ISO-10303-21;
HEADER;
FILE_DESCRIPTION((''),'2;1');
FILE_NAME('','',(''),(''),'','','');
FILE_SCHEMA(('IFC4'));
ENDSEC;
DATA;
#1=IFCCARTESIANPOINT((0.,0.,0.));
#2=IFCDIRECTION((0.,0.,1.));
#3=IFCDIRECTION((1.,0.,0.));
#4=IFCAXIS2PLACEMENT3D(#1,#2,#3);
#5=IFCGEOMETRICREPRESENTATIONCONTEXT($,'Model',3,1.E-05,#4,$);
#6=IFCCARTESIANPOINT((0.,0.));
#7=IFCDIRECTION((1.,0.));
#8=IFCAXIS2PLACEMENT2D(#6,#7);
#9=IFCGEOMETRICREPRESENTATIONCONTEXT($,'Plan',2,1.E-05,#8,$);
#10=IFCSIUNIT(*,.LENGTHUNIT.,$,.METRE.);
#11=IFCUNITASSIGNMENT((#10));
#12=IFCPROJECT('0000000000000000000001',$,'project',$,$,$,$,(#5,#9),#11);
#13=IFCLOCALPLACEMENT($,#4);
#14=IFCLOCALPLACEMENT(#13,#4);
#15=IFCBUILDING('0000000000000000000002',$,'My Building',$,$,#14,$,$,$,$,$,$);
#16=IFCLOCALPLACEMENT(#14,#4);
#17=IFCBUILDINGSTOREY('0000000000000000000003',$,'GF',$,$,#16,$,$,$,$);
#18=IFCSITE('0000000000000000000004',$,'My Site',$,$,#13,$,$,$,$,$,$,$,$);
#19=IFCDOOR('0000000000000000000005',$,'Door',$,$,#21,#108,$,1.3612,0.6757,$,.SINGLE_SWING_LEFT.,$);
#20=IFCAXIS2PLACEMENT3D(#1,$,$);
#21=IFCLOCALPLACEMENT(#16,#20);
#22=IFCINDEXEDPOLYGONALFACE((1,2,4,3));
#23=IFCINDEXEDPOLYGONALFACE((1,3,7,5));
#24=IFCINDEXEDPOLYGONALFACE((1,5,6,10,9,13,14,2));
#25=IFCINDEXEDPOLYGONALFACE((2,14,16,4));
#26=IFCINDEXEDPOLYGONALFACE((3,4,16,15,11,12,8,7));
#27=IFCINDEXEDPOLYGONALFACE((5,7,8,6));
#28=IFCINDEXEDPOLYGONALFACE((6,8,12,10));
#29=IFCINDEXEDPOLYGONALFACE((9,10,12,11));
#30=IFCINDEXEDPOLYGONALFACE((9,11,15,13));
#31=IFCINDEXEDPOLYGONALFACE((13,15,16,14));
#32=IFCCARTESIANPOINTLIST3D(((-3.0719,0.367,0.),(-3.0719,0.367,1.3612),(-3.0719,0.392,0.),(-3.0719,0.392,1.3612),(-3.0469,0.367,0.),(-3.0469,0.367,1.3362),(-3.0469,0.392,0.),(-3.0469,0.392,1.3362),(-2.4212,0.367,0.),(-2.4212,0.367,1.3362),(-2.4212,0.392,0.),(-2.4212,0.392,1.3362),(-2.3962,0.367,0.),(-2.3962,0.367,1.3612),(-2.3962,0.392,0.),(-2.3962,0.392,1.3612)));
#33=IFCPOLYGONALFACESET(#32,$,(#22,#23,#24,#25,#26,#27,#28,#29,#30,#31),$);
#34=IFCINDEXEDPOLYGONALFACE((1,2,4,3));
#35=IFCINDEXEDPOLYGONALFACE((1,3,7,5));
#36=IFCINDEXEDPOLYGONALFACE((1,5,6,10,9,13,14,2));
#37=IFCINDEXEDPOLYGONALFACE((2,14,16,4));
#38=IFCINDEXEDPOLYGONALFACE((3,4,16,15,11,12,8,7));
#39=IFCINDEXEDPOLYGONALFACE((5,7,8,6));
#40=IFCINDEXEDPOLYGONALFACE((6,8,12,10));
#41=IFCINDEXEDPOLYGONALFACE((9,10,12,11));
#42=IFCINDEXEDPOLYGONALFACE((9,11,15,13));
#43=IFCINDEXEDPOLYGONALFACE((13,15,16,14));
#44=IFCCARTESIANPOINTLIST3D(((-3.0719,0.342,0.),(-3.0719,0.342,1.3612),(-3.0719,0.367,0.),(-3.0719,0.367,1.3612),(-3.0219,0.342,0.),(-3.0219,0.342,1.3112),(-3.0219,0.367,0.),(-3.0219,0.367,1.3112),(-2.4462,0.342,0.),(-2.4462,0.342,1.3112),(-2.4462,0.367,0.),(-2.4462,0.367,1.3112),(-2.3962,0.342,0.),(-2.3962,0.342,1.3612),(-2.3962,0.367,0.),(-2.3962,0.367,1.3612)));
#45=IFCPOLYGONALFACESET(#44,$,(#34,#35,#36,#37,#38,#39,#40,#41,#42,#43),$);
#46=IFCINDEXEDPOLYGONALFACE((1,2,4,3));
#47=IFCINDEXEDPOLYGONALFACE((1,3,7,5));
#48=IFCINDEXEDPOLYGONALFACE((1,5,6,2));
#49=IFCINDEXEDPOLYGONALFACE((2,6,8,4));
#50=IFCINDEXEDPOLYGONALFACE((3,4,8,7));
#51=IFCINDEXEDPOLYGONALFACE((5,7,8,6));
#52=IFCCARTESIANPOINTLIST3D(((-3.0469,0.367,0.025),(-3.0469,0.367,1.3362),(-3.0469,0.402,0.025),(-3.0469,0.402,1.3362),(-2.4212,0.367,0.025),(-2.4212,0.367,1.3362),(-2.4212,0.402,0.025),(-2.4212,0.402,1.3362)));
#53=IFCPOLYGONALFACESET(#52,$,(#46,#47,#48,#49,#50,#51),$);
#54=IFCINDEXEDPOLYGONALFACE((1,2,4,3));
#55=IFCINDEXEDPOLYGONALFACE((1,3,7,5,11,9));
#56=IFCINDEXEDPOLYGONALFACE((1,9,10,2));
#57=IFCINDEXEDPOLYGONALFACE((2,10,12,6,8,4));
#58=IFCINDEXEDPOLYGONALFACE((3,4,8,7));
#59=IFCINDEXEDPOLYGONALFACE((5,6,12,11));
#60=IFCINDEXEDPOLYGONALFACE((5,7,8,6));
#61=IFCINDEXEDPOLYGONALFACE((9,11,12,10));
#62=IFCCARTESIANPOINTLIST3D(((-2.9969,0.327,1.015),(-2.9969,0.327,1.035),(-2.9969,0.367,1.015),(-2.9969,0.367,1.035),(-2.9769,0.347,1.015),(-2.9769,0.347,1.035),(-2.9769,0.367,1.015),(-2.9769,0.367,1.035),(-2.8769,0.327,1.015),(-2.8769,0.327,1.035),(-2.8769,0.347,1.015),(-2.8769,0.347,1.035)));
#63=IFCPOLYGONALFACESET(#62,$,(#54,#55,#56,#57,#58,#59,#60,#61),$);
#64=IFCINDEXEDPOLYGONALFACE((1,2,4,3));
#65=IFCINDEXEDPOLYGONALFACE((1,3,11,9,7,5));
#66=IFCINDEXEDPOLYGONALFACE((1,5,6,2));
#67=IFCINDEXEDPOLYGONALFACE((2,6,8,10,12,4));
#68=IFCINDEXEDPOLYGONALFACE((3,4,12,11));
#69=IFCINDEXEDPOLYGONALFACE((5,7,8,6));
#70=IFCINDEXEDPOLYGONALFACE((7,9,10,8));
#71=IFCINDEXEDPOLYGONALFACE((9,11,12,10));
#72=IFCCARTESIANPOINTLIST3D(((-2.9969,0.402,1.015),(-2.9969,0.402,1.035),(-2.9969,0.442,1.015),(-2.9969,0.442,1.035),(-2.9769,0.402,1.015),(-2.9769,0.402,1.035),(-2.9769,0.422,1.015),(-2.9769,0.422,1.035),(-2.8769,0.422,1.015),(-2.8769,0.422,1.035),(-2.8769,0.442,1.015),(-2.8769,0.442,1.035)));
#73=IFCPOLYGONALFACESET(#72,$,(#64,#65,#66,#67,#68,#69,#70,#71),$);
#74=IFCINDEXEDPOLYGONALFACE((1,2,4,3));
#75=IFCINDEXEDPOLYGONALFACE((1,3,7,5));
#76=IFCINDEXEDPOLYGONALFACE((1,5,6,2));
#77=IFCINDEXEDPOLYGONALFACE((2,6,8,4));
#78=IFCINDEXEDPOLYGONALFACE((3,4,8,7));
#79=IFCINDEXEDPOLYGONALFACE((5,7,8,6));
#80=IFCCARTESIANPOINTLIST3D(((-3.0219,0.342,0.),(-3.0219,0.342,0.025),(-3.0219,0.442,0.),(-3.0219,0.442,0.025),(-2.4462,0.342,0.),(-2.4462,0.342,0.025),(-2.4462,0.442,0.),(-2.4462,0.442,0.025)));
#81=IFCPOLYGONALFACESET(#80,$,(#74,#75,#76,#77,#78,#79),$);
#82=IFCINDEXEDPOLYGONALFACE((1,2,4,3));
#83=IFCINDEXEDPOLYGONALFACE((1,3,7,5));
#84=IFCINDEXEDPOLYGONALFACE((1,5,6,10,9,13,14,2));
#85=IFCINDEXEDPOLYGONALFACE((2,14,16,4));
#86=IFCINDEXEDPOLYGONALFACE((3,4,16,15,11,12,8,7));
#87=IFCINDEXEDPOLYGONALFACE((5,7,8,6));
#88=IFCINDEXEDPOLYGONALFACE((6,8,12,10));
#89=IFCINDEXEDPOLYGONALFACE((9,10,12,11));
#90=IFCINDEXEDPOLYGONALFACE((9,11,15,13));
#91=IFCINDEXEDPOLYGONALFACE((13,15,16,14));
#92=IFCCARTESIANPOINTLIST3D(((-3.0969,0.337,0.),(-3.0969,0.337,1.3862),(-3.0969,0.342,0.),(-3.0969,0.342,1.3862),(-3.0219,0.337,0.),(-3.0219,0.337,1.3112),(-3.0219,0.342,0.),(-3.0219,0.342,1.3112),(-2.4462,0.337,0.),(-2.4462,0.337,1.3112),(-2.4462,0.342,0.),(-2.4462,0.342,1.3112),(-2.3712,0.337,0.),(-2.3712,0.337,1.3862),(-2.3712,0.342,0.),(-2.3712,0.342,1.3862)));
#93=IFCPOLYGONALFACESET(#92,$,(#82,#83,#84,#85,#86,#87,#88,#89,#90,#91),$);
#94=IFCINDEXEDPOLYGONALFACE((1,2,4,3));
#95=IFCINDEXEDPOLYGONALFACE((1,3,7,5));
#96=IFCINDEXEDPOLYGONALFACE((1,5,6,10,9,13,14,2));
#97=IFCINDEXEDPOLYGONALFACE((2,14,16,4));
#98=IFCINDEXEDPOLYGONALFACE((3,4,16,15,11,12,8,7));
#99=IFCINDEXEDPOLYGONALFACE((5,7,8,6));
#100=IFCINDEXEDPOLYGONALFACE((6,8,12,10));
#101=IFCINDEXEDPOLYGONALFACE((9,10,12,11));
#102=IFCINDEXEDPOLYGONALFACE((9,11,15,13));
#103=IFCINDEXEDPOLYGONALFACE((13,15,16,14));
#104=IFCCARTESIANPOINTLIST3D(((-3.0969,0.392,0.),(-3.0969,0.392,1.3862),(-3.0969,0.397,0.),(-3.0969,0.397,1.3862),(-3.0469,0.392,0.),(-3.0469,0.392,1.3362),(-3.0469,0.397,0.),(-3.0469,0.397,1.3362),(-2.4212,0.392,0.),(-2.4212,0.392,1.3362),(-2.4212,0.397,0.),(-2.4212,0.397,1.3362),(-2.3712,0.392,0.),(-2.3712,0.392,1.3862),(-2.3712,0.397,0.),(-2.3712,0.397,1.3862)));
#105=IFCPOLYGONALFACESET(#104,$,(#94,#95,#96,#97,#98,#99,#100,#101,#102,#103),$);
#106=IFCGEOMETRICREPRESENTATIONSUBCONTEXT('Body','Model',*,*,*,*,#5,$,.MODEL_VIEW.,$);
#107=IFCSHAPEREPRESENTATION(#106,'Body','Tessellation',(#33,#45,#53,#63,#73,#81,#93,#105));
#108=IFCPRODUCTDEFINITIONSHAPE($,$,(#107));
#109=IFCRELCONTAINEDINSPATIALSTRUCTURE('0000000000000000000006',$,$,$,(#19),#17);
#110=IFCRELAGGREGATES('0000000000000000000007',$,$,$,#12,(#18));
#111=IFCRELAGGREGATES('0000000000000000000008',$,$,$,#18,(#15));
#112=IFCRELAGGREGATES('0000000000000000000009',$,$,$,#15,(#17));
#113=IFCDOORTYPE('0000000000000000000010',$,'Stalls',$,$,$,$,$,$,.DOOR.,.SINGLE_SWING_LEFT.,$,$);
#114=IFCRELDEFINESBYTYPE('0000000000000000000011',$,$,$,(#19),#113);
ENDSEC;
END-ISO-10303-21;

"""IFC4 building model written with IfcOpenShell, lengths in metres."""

from ifc_helpers import new_model, entity, si_unit, frame, origin_with_axes, origin_2d_with_axis, place, context, subcontext, project, spatial, line, indexed_curve, outline, extrude, shape, source, transform, mapped, type_object, type_shapes, element, save


model = new_model("IFC4")

# Units and contexts
model_context = context("Model", 3, precision=1e-05, world=origin_with_axes())
plan_context = context("Plan", 2, precision=1e-05, world=origin_2d_with_axis())
body_context_1 = subcontext(model_context, "Body", "Model", "MODEL_VIEW")
body_context_2 = subcontext(plan_context, "Body", "Plan", "PLAN_VIEW")
ifc_project = project(units=[si_unit("LENGTHUNIT", "METRE")], contexts=[model_context, plan_context])

# Site, building, storey
site_placement = place(None, origin_with_axes())
site = spatial("IfcSite", under=ifc_project, at=site_placement, Name="My Site")
building_placement = place(site_placement, origin_with_axes())
building = spatial("IfcBuilding", under=site, at=building_placement, Name="My Building")
storey_placement = place(building_placement, origin_with_axes())
storey = spatial("IfcBuildingStorey", under=building, at=storey_placement, Name="GF")

# Shared definitions
door_type = type_object("IfcDoorType", Name="Stalls", OperationType="SINGLE_SWING_LEFT", PredefinedType="DOOR")
shared_shape_1 = source(origin_with_axes(), body_context_1, "Body", "SweptSolid", [
    extrude(outline(indexed_curve([(0.0, 0.0), (0.0, 1.3612), (0.6757, 1.3612), (0.6757, 0.0), (0.6507, 0.0), (0.6507, 1.3362), (0.025, 1.3362), (0.025, 0.0)], segments=[line(1, 2, 3, 4, 5, 6, 7, 8, 1)])), frame((0.0, 0.025, 0.0), z_axis=(0.0, -1.0, 0.0), x_axis=(1.0, 0.0, 0.0)), (0.0, 0.0, -1.0), 0.025),
    extrude(outline(indexed_curve([(0.0, 0.0), (0.0, 1.3612), (0.6757, 1.3612), (0.6757, 0.0), (0.6257, 0.0), (0.6257, 1.3112), (0.05, 1.3112), (0.05, 0.0)], segments=[line(1, 2, 3, 4, 5, 6, 7, 8, 1)])), frame((0.0, 0.0, 0.0), z_axis=(0.0, -1.0, 0.0), x_axis=(1.0, 0.0, 0.0)), (0.0, 0.0, -1.0), 0.025),
    extrude(outline(indexed_curve([(0.0, 0.0), (0.6257, 0.0), (0.6257, 0.035), (0.0, 0.035)], segments=[line(1, 2, 3, 4, 1)])), frame((0.025, 0.025, 0.025), z_axis=(0.0, 0.0, 1.0), x_axis=(1.0, 0.0, 0.0)), (0.0, 0.0, 1.0), 1.3112),
    extrude(outline(indexed_curve([(0.0, 0.0), (0.0, -0.04), (0.12, -0.04), (0.12, -0.02), (0.02, -0.02), (0.02, 0.0)], segments=[line(1, 2, 3, 4, 5, 6, 1)])), frame((0.075, 0.025, 1.015), z_axis=(0.0, 0.0, 1.0), x_axis=(1.0, 0.0, 0.0)), (0.0, 0.0, 1.0), 0.02),
    extrude(outline(indexed_curve([(0.0, 0.0), (0.0, 0.04), (0.12, 0.04), (0.12, 0.02), (0.02, 0.02), (0.02, 0.0)], segments=[line(1, 2, 3, 4, 5, 6, 1)])), frame((0.075, 0.06, 1.015), z_axis=(0.0, 0.0, 1.0), x_axis=(1.0, 0.0, 0.0)), (0.0, 0.0, 1.0), 0.02),
    extrude(outline(indexed_curve([(0.0, 0.0), (0.5757, 0.0), (0.5757, 0.1), (0.0, 0.1)], segments=[line(1, 2, 3, 4, 1)])), frame((0.05, 0.0, 0.0), z_axis=(0.0, 0.0, 1.0), x_axis=(1.0, 0.0, 0.0)), (0.0, 0.0, 1.0), 0.025),
    extrude(outline(indexed_curve([(0.0, 0.0), (0.0, 1.3862), (0.7257, 1.3862), (0.7257, 0.0), (0.6507, 0.0), (0.6507, 1.3112), (0.075, 1.3112), (0.075, 0.0)], segments=[line(1, 2, 3, 4, 5, 6, 7, 8, 1)])), frame((-0.025, -0.005, 0.0), z_axis=(0.0, -1.0, 0.0), x_axis=(1.0, 0.0, 0.0)), (0.0, 0.0, -1.0), 0.005),
    extrude(outline(indexed_curve([(0.0, 0.0), (0.0, 1.3862), (0.7257, 1.3862), (0.7257, 0.0), (0.6757, 0.0), (0.6757, 1.3362), (0.05, 1.3362), (0.05, 0.0)], segments=[line(1, 2, 3, 4, 5, 6, 7, 8, 1)])), frame((-0.025, 0.05, 0.0), z_axis=(0.0, -1.0, 0.0), x_axis=(1.0, 0.0, 0.0)), (0.0, 0.0, -1.0), 0.005),
])
shared_shape_2 = source(origin_with_axes(), body_context_2, "Body", "Curve2D", [
    entity("IfcIndexedPolyCurve", entity("IfcCartesianPointList2D", [[0.0, 0.0], [0.0, 0.05], [0.025, 0.05], [0.025, 0.025], [0.05, 0.025], [0.05, 0.0]]), [entity("IfcLineIndex", [1, 2, 3, 4, 5, 6, 1])]),
    entity("IfcIndexedPolyCurve", entity("IfcCartesianPointList2D", [[0.6757, 0.0], [0.6757, 0.05], [0.6507, 0.05], [0.6507, 0.025], [0.6257, 0.025], [0.6257, 0.0]]), [entity("IfcLineIndex", [1, 2, 3, 4, 5, 6, 1])]),
    entity("IfcTrimmedCurve", entity("IfcEllipse", entity("IfcAxis2Placement2D", entity("IfcCartesianPoint", [0.6157, 0.05]), entity("IfcDirection", [1.0, 0.0])), 0.5907, 0.6257), [entity("IfcCartesianPoint", [0.6157, 0.6757])], [entity("IfcCartesianPoint", [0.025, 0.05])], True, "CARTESIAN"),
    entity("IfcIndexedPolyCurve", entity("IfcCartesianPointList2D", [[0.6507, 0.05], [0.6157, 0.05], [0.6157, 0.6757], [0.6507, 0.6757]]), [entity("IfcLineIndex", [1, 2, 3, 4, 1])]),
])
type_shapes(door_type, [shared_shape_1, shared_shape_2])

# Door
door_1_placement = place(storey_placement, frame((-3.0719, 0.342, 0.0), z_axis=(0.0, 0.0, 1.0), x_axis=(1.0, 0.0, 0.0)))
element("IfcDoor", 1, at=door_1_placement, inside=storey, type_object=door_type, Name="Door", OperationType="SINGLE_SWING_LEFT", OverallHeight=1.3612, OverallWidth=0.6757, shapes=[
    shape(body_context_1, "Body", "MappedRepresentation", [mapped(shared_shape_1, transform((0.0, 0.0, 0.0), x_axis=(1.0, 0.0, 0.0), y_axis=(0.0, 1.0, 0.0), z_axis=(0.0, 0.0, 1.0), scale=1.0))]),
    shape(body_context_2, "Body", "MappedRepresentation", [mapped(shared_shape_2, transform((0.0, 0.0, 0.0), x_axis=(1.0, 0.0, 0.0), y_axis=(0.0, 1.0, 0.0), z_axis=(0.0, 0.0, 1.0), scale=1.0))]),
])

save(model, "model.ifc")
